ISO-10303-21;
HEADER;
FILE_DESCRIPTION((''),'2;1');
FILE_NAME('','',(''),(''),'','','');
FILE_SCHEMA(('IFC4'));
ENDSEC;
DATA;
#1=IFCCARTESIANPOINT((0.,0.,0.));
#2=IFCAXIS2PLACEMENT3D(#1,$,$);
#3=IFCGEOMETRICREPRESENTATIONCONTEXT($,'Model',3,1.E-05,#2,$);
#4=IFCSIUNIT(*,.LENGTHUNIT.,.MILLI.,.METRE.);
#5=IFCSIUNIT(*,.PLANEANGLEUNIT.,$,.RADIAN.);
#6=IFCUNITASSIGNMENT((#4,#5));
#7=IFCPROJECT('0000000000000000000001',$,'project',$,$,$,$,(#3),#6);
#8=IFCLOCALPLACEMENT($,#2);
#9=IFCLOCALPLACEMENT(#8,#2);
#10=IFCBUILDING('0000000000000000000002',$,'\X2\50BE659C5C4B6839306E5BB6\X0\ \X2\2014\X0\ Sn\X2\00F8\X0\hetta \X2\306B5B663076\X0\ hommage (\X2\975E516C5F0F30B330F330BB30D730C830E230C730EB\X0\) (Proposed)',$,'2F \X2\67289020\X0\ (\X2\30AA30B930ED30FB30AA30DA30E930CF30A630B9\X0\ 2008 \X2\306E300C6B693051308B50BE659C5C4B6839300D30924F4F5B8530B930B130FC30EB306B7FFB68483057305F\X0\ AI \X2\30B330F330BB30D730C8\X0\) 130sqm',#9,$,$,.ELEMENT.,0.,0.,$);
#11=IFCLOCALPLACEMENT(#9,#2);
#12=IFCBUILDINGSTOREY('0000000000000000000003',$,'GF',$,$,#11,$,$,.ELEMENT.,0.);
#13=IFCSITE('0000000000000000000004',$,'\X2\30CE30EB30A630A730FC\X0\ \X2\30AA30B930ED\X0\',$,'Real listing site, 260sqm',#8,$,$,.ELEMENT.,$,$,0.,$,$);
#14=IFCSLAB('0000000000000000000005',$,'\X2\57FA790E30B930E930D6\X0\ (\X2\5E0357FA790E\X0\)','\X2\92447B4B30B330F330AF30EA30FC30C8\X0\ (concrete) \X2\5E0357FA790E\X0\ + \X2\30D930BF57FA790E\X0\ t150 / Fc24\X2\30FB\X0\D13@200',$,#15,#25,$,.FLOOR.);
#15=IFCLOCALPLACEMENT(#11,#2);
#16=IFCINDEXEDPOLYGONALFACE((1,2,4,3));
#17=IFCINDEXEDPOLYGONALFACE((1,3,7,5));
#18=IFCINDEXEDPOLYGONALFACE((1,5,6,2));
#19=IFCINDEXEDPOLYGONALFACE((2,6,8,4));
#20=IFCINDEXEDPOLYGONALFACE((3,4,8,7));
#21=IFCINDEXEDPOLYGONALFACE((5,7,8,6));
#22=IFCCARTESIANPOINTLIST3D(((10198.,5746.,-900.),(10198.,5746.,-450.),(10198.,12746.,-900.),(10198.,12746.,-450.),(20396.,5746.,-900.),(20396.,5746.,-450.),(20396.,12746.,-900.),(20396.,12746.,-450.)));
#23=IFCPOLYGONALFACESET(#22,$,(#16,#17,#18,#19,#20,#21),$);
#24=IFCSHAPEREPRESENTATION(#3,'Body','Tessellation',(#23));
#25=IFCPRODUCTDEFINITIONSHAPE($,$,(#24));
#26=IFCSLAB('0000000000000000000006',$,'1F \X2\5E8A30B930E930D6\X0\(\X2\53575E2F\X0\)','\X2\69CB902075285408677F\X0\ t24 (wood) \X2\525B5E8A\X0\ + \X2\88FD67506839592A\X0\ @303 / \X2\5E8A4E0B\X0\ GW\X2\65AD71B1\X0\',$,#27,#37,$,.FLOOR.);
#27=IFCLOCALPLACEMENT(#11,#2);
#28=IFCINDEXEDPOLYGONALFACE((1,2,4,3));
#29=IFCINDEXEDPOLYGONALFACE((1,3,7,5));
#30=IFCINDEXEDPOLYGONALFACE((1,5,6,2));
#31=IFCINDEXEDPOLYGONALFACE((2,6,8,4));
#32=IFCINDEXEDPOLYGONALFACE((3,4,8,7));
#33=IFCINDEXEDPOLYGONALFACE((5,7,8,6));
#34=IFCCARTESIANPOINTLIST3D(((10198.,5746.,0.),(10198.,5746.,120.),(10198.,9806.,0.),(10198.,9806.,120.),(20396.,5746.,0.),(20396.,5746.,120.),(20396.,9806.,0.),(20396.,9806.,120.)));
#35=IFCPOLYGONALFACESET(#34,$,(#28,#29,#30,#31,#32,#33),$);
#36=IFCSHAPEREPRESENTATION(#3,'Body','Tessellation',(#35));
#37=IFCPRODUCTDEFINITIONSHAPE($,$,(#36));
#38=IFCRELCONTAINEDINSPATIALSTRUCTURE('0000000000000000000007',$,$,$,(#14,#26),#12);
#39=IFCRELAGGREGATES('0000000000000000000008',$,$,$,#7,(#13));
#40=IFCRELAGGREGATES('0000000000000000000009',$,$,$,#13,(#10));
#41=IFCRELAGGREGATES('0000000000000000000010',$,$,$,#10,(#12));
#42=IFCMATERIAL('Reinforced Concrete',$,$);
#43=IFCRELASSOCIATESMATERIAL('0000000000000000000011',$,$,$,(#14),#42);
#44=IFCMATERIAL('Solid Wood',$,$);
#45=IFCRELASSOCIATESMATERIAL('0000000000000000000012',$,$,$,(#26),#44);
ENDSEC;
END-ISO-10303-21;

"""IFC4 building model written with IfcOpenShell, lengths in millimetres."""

from ifc_helpers import new_model, si_unit, frame, frame_2d, origin, place, context, project, spatial, rectangle, extrude, material, element, save


model = new_model("IFC4")

# Units and contexts
model_context = context("Model", 3, precision=1e-05, world=origin())
ifc_project = project(units=[si_unit("LENGTHUNIT", "METRE", prefix="MILLI"), si_unit("PLANEANGLEUNIT", "RADIAN")], contexts=[model_context])

# Site, building, storey
site_placement = place(None, origin())
site = spatial("IfcSite", under=ifc_project, at=site_placement, Name="ノルウェー オスロ", ObjectType="Real listing site, 260sqm", CompositionType="ELEMENT", RefElevation=0.0)
building_placement = place(site_placement, origin())
building = spatial("IfcBuilding", under=site, at=building_placement, Name="傾斜屋根の家 — Snøhetta に学ぶ hommage (非公式コンセプトモデル) (Proposed)", ObjectType="2F 木造 (オスロ・オペラハウス 2008 の「歩ける傾斜屋根」を住宅スケールに翻案した AI コンセプト) 130sqm", CompositionType="ELEMENT", ElevationOfRefHeight=0.0, ElevationOfTerrain=0.0)
storey_placement = place(building_placement, origin())
storey = spatial("IfcBuildingStorey", under=building, at=storey_placement, Name="GF", CompositionType="ELEMENT", Elevation=0.0)

# Slabs
ifc_material_1 = material(Name="Reinforced Concrete")
slab_1_placement = place(storey_placement, frame((5099.0, 2873.0, -450.0)))
element("IfcSlab", 1, at=slab_1_placement, inside=storey, material=ifc_material_1, Name="基礎スラブ (布基礎)", Description="鉄筋コンクリート (concrete) 布基礎 + ベタ基礎 t150 / Fc24・D13@200", PredefinedType="FLOOR", context=model_context, shape_type="SweptSolid", body=[
    extrude(rectangle(XDim=10198.0, YDim=7000.0, at=frame_2d((5099.0, 3500.0))), frame((5099.0, 2873.0, -450.0)), (0.0, 0.0, 1.0), 450.0),
])
ifc_material_2 = material(Name="Solid Wood")
slab_2_placement = place(storey_placement, frame((5099.0, 2873.0, 0.0)))
element("IfcSlab", 2, at=slab_2_placement, inside=storey, material=ifc_material_2, Name="1F 床スラブ(南帯)", Description="構造用合板 t24 (wood) 剛床 + 製材根太 @303 / 床下 GW断熱", PredefinedType="FLOOR", context=model_context, shape_type="SweptSolid", body=[
    extrude(rectangle(XDim=10198.0, YDim=4060.0, at=frame_2d((5099.0, 2030.0))), frame((5099.0, 2873.0, 0.0)), (0.0, 0.0, 1.0), 120.0),
])

save(model, "model.ifc")
